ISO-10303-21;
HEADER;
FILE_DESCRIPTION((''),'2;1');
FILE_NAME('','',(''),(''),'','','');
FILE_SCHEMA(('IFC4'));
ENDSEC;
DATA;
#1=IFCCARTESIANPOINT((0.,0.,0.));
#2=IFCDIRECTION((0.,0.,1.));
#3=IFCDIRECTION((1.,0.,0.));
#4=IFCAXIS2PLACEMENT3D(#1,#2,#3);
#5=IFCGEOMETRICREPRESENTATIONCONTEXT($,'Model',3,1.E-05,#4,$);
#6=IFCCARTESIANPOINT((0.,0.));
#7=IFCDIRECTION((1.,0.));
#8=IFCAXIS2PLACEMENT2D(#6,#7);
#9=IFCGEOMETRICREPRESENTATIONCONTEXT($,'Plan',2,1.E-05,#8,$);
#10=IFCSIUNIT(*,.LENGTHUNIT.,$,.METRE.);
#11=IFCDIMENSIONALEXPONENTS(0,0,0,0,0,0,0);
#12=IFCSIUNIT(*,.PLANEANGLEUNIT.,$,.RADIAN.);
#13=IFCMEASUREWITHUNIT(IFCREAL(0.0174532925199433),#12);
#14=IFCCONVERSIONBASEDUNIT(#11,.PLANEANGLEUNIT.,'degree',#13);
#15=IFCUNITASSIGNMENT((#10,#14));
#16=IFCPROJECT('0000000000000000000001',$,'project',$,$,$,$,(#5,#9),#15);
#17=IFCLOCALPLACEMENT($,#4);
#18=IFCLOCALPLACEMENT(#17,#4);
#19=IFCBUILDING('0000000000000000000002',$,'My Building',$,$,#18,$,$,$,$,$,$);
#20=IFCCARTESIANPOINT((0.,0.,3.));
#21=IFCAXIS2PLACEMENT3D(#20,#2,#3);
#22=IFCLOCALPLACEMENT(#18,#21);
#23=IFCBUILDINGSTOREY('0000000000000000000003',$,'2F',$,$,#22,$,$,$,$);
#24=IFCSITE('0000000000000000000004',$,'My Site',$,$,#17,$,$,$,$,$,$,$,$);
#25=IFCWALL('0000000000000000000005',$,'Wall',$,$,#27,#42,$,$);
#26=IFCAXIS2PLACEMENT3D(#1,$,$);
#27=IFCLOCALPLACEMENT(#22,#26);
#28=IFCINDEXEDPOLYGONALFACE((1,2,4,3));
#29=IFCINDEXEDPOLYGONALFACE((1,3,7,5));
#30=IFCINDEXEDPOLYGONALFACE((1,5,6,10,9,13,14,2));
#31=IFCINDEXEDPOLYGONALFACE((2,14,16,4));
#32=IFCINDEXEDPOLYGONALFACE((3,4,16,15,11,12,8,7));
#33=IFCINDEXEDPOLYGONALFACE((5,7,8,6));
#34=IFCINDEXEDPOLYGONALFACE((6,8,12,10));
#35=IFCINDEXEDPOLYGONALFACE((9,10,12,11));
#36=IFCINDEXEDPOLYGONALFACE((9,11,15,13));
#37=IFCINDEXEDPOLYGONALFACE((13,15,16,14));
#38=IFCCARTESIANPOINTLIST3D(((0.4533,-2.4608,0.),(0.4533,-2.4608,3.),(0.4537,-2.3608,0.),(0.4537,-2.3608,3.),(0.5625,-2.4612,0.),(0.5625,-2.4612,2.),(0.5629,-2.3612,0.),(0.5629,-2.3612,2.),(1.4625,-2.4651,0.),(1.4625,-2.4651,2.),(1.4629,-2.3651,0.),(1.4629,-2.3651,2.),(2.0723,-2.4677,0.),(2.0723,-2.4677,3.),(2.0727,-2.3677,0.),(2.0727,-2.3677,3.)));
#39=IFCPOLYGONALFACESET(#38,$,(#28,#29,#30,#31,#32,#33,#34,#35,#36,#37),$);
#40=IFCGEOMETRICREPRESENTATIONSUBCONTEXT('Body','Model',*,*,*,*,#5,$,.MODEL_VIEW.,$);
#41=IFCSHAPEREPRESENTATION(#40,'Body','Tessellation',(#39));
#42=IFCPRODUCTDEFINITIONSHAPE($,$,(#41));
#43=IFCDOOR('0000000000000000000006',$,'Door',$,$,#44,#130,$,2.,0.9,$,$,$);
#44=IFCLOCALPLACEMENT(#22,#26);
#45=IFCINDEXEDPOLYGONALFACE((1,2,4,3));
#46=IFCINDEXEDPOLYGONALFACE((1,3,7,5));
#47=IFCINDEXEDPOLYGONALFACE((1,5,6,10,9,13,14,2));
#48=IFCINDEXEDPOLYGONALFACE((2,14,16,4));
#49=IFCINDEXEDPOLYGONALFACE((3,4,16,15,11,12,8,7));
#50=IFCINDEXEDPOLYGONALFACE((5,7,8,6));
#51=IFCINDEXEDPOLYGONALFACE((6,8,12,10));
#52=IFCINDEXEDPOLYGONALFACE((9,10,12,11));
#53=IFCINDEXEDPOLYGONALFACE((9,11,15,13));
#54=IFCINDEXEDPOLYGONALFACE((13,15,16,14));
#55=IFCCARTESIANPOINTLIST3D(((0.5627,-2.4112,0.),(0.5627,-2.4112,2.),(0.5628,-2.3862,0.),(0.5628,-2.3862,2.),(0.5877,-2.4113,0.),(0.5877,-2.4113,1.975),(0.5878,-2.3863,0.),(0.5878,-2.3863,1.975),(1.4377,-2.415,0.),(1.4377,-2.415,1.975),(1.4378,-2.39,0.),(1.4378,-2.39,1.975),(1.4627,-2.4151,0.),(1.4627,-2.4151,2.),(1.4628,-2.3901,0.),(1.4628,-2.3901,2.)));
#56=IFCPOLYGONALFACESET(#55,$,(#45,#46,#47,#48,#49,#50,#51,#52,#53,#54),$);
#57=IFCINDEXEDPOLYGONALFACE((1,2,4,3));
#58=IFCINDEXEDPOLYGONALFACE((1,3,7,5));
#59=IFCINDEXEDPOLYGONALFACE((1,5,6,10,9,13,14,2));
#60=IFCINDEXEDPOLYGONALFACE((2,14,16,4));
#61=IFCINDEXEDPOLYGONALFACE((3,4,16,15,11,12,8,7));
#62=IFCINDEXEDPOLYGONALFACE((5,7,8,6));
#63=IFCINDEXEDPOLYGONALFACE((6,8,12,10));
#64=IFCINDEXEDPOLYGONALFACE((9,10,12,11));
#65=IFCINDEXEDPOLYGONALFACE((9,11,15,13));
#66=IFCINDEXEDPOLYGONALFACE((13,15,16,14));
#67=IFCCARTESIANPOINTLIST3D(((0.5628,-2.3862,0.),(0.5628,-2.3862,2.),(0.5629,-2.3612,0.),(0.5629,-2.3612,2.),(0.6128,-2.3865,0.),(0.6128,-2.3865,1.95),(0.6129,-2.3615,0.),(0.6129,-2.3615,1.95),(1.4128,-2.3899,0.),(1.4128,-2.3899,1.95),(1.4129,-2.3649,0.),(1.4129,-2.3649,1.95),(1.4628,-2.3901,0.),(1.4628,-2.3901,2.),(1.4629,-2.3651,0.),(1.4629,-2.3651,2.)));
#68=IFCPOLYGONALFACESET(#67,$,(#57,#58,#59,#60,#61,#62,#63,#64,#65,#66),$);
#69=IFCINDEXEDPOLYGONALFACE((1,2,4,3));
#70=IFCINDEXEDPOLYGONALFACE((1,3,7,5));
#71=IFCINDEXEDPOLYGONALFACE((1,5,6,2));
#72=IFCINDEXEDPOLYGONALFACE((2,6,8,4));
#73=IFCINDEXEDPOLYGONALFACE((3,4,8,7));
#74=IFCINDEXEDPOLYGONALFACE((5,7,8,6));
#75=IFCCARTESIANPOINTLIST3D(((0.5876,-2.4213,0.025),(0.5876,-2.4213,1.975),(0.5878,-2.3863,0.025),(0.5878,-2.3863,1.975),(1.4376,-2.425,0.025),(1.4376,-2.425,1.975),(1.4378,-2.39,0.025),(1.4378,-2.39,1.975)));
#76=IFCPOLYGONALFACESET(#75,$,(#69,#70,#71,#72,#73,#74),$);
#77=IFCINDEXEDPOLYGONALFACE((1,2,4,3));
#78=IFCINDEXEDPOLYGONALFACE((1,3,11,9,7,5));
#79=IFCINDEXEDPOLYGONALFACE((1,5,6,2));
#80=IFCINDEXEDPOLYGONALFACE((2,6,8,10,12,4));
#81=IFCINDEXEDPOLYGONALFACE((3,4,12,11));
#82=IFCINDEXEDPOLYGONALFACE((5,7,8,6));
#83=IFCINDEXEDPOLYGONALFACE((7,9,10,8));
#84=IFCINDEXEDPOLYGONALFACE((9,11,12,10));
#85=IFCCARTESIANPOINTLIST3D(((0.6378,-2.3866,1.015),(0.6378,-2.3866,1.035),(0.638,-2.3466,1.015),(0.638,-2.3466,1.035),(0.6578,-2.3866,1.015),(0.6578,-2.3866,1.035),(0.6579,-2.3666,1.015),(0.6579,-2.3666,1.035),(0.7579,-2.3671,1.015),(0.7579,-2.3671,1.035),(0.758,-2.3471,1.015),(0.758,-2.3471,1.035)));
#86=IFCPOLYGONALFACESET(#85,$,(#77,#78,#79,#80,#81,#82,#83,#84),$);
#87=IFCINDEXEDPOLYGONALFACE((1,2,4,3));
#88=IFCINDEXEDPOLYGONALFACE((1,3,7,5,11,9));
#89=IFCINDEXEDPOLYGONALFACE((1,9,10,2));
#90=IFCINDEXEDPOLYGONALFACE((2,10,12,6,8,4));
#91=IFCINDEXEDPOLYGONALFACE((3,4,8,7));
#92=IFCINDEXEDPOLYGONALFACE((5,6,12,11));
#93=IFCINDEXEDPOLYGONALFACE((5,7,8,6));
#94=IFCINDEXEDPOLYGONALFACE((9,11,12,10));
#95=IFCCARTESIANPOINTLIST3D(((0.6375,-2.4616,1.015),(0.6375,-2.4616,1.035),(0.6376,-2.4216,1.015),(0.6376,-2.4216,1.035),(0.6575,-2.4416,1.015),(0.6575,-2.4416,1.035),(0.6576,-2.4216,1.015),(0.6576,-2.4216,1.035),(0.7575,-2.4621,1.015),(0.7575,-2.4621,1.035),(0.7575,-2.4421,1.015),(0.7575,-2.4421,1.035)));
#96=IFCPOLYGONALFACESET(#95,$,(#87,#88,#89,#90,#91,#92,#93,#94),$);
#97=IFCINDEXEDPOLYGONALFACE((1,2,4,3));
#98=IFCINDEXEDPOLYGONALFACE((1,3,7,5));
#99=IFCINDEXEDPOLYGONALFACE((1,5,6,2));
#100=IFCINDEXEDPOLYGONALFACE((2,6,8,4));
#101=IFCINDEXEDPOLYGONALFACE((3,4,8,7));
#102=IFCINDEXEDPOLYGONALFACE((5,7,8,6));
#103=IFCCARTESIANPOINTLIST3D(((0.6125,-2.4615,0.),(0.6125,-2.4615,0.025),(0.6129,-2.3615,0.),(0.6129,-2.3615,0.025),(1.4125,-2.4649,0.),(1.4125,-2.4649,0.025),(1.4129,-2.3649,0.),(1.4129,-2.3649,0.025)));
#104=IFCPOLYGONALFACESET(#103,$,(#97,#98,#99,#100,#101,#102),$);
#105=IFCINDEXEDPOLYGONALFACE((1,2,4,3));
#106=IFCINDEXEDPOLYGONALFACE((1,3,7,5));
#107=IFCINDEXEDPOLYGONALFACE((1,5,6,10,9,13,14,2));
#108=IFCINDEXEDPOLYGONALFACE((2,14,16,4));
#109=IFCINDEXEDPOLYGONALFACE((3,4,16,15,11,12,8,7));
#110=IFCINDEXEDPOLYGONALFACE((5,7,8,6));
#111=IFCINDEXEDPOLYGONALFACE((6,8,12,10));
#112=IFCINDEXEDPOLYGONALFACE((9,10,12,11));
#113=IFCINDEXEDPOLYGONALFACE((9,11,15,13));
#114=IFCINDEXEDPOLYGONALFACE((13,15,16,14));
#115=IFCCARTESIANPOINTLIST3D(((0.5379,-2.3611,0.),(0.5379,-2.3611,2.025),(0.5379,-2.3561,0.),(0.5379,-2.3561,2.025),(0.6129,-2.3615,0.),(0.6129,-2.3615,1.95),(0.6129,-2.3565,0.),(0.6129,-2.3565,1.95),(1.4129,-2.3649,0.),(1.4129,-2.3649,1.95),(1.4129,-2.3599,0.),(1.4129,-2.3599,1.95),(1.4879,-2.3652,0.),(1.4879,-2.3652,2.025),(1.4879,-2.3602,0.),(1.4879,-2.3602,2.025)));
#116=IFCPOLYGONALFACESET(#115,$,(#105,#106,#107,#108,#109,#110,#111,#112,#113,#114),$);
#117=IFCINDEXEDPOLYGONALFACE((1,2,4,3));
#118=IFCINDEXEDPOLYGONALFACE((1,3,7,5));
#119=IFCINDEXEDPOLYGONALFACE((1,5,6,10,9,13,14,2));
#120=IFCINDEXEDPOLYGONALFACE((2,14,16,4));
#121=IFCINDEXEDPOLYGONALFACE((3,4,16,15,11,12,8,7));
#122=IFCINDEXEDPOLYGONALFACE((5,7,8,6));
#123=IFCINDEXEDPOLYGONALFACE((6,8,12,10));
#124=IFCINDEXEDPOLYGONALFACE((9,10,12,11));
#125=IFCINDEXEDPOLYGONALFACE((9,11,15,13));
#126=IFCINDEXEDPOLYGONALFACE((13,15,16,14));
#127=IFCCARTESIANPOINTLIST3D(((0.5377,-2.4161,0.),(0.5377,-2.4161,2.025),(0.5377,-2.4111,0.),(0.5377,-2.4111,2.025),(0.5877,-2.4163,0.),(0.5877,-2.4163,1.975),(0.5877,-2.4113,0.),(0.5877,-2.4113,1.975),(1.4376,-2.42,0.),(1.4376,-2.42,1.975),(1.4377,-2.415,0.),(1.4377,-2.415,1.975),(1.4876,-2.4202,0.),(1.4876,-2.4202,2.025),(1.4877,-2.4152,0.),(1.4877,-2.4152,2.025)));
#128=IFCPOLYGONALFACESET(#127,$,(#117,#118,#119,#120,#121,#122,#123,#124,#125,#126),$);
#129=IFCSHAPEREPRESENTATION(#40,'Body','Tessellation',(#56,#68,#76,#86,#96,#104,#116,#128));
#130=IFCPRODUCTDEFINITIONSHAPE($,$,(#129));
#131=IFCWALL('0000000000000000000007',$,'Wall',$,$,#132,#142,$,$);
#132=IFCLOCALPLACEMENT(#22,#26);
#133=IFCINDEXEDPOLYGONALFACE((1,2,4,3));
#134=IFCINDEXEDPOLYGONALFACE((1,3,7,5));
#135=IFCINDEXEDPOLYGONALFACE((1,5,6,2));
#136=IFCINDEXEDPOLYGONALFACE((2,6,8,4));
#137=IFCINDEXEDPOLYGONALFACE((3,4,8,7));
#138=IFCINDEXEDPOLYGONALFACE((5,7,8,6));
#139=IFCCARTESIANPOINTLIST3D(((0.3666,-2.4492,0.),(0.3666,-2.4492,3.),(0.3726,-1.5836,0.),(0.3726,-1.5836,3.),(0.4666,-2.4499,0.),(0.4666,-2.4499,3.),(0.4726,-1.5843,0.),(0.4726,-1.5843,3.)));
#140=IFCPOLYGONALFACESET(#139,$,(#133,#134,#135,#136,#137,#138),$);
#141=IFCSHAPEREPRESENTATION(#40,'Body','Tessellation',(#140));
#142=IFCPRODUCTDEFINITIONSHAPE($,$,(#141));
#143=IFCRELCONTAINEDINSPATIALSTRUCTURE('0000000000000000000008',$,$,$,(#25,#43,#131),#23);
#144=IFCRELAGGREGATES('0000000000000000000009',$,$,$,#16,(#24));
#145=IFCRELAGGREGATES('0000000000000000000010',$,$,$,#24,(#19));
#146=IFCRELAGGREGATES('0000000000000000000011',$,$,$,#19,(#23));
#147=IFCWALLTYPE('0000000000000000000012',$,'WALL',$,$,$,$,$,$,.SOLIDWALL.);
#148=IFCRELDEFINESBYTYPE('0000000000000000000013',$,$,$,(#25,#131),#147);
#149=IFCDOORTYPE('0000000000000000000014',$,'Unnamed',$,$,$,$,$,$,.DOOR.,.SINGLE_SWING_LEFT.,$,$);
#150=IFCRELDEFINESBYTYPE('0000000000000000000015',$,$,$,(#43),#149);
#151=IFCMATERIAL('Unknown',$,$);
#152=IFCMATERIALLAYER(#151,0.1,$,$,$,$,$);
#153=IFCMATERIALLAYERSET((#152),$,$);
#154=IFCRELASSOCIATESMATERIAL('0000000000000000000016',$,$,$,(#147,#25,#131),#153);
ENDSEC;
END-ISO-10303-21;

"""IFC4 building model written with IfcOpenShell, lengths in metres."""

from ifc_helpers import new_model, entity, si_unit, converted_unit, frame, origin_with_axes, origin_2d_with_axis, place, context, subcontext, project, spatial, line, indexed_curve, outline, extrude, shape, source, transform, mapped, material, layer, layer_set, layer_usage, type_object, type_shapes, element, fill, save


model = new_model("IFC4")

# Units and contexts
model_context = context("Model", 3, precision=1e-05, world=origin_with_axes())
plan_context = context("Plan", 2, precision=1e-05, world=origin_2d_with_axis())
body_context_1 = subcontext(model_context, "Body", "Model", "MODEL_VIEW")
body_context_2 = subcontext(plan_context, "Body", "Plan", "PLAN_VIEW")
ifc_project = project(units=[si_unit("LENGTHUNIT", "METRE"), converted_unit("PLANEANGLEUNIT", "degree", entity("IfcReal", 0.0174532925199433), si_unit("PLANEANGLEUNIT", "RADIAN"), dimensions=[0, 0, 0, 0, 0, 0, 0])], contexts=[model_context, plan_context])

# Site, building, storey
site_placement = place(None, origin_with_axes())
site = spatial("IfcSite", under=ifc_project, at=site_placement, Name="My Site")
building_placement = place(site_placement, origin_with_axes())
building = spatial("IfcBuilding", under=site, at=building_placement, Name="My Building")
storey_placement = place(building_placement, frame((0.0, 0.0, 3.0), z_axis=(0.0, 0.0, 1.0), x_axis=(1.0, 0.0, 0.0)))
storey = spatial("IfcBuildingStorey", under=building, at=storey_placement, Name="2F")

# Shared definitions
ifc_material = material(Name="Unknown")

# Shared definitions
ifc_layer_1 = layer(ifc_material, 0.1)
ifc_layer_set_1 = layer_set([ifc_layer_1])
wall_type = type_object("IfcWallType", Name="WALL", PredefinedType="SOLIDWALL", material=ifc_layer_set_1)

# Shared definitions
shared_shape_1 = source(origin_with_axes(), body_context_1, "Body", "SweptSolid", [
    extrude(outline(indexed_curve([(0.0, 0.0), (0.9, 0.0), (0.9, 2.0), (0.0, 2.0)], segments=[line(1, 2, 3, 4, 1)])), frame((0.0, -0.6, 0.0), z_axis=(0.0, -1.0, 0.0), x_axis=(1.0, 0.0, 0.0)), (0.0, 0.0, -1.0), 1.2),
])
door_type = type_object("IfcDoorType", Name="Unnamed", OperationType="SINGLE_SWING_LEFT", PredefinedType="DOOR")
shared_shape_2 = source(origin_with_axes(), body_context_1, "Body", "SweptSolid", [
    extrude(outline(indexed_curve([(0.0, 0.0), (0.0, 2.0), (0.9, 2.0), (0.9, 0.0), (0.875, 0.0), (0.875, 1.975), (0.025, 1.975), (0.025, 0.0)], segments=[line(1, 2, 3, 4, 5, 6, 7, 8, 1)])), frame((0.0, 0.025, 0.0), z_axis=(0.0, -1.0, 0.0), x_axis=(1.0, 0.0, 0.0)), (0.0, 0.0, -1.0), 0.025),
    extrude(outline(indexed_curve([(0.0, 0.0), (0.0, 2.0), (0.9, 2.0), (0.9, 0.0), (0.85, 0.0), (0.85, 1.95), (0.05, 1.95), (0.05, 0.0)], segments=[line(1, 2, 3, 4, 5, 6, 7, 8, 1)])), frame((0.0, 0.0, 0.0), z_axis=(0.0, -1.0, 0.0), x_axis=(1.0, 0.0, 0.0)), (0.0, 0.0, -1.0), 0.025),
    extrude(outline(indexed_curve([(0.0, 0.0), (0.85, 0.0), (0.85, 0.035), (0.0, 0.035)], segments=[line(1, 2, 3, 4, 1)])), frame((0.025, 0.025, 0.025), z_axis=(0.0, 0.0, 1.0), x_axis=(1.0, 0.0, 0.0)), (0.0, 0.0, 1.0), 1.95),
    extrude(outline(indexed_curve([(0.0, 0.0), (0.0, -0.04), (-0.12, -0.04), (-0.12, -0.02), (-0.02, -0.02), (-0.02, 0.0)], segments=[line(1, 2, 3, 4, 5, 6, 1)])), frame((0.825, 0.025, 1.015), z_axis=(0.0, 0.0, 1.0), x_axis=(1.0, 0.0, 0.0)), (0.0, 0.0, 1.0), 0.02),
    extrude(outline(indexed_curve([(0.0, 0.0), (0.0, 0.04), (-0.12, 0.04), (-0.12, 0.02), (-0.02, 0.02), (-0.02, 0.0)], segments=[line(1, 2, 3, 4, 5, 6, 1)])), frame((0.825, 0.06, 1.015), z_axis=(0.0, 0.0, 1.0), x_axis=(1.0, 0.0, 0.0)), (0.0, 0.0, 1.0), 0.02),
    extrude(outline(indexed_curve([(0.0, 0.0), (0.8, 0.0), (0.8, 0.1), (0.0, 0.1)], segments=[line(1, 2, 3, 4, 1)])), frame((0.05, 0.0, 0.0), z_axis=(0.0, 0.0, 1.0), x_axis=(1.0, 0.0, 0.0)), (0.0, 0.0, 1.0), 0.025),
    extrude(outline(indexed_curve([(0.0, 0.0), (0.0, 2.025), (0.95, 2.025), (0.95, 0.0), (0.875, 0.0), (0.875, 1.95), (0.075, 1.95), (0.075, 0.0)], segments=[line(1, 2, 3, 4, 5, 6, 7, 8, 1)])), frame((-0.025, -0.005, 0.0), z_axis=(0.0, -1.0, 0.0), x_axis=(1.0, 0.0, 0.0)), (0.0, 0.0, -1.0), 0.005),
    extrude(outline(indexed_curve([(0.0, 0.0), (0.0, 2.025), (0.95, 2.025), (0.95, 0.0), (0.9, 0.0), (0.9, 1.975), (0.05, 1.975), (0.05, 0.0)], segments=[line(1, 2, 3, 4, 5, 6, 7, 8, 1)])), frame((-0.025, 0.05, 0.0), z_axis=(0.0, -1.0, 0.0), x_axis=(1.0, 0.0, 0.0)), (0.0, 0.0, -1.0), 0.005),
])
shared_shape_3 = source(origin_with_axes(), body_context_2, "Body", "Curve2D", [
    entity("IfcIndexedPolyCurve", entity("IfcCartesianPointList2D", [[0.0, 0.0], [0.0, 0.05], [0.025, 0.05], [0.025, 0.025], [0.05, 0.025], [0.05, 0.0]]), [entity("IfcLineIndex", [1, 2, 3, 4, 5, 6, 1])]),
    entity("IfcIndexedPolyCurve", entity("IfcCartesianPointList2D", [[0.9, 0.0], [0.9, 0.05], [0.875, 0.05], [0.875, 0.025], [0.85, 0.025], [0.85, 0.0]]), [entity("IfcLineIndex", [1, 2, 3, 4, 5, 6, 1])]),
    entity("IfcTrimmedCurve", entity("IfcEllipse", entity("IfcAxis2Placement2D", entity("IfcCartesianPoint", [0.06, 0.05]), entity("IfcDirection", [1.0, 0.0])), 0.815, 0.85), [entity("IfcCartesianPoint", [0.875, 0.05])], [entity("IfcCartesianPoint", [0.06, 0.9])], True, "CARTESIAN"),
    entity("IfcIndexedPolyCurve", entity("IfcCartesianPointList2D", [[0.025, 0.05], [0.06, 0.05], [0.06, 0.9], [0.025, 0.9]]), [entity("IfcLineIndex", [1, 2, 3, 4, 1])]),
])
type_shapes(door_type, [shared_shape_2, shared_shape_3])

# Wall, opening, door
ifc_layer_usage_1 = layer_usage(ifc_layer_set_1, "AXIS2", "POSITIVE", 0.0)
wall_1_placement = place(storey_placement, frame((2.0727, -2.3677, 0.0), z_axis=(0.0, 0.0, 1.0), x_axis=(-0.999991, 0.00431, 0.0)))
wall_1 = element("IfcWall", 1, at=wall_1_placement, inside=storey, type_object=wall_type, material=ifc_layer_usage_1, Name="Wall", context=body_context_1, shape_type="SweptSolid", body=[
    extrude(outline(indexed_curve([(0.0, 0.0), (0.0, 0.1), (1.619, 0.1), (1.619, 0.0)], segments=[line(1, 2, 3, 4, 1)])), origin_with_axes(), (0.0, 0.0, 1.0), 3.0),
])
opening_1_placement = place(wall_1_placement, frame((0.6098, 0.0, 0.0), z_axis=(0.0, 0.0, 1.0), x_axis=(1.0, 0.0, 0.0)))
opening_1 = element("IfcOpeningElement", 2, at=opening_1_placement, cuts=wall_1, PredefinedType="OPENING", context=body_context_1, shape_type="MappedRepresentation", body=[
    mapped(shared_shape_1, transform((0.0, 0.0, 0.0), x_axis=(1.0, 0.0, 0.0), y_axis=(0.0, 1.0, 0.0), z_axis=(0.0, 0.0, 1.0), scale=1.0)),
])
door_1_placement = place(opening_1_placement, frame((0.0, 0.0, 0.0), z_axis=(0.0, 0.0, 1.0), x_axis=(1.0, 0.0, 0.0)))
door_1 = element("IfcDoor", 3, at=door_1_placement, inside=storey, type_object=door_type, Name="Door", OverallHeight=2.0, OverallWidth=0.9, shapes=[
    shape(body_context_1, "Body", "MappedRepresentation", [mapped(shared_shape_2, transform((0.0, 0.0, 0.0), x_axis=(1.0, 0.0, 0.0), y_axis=(0.0, 1.0, 0.0), z_axis=(0.0, 0.0, 1.0), scale=1.0))]),
    shape(body_context_2, "Body", "MappedRepresentation", [mapped(shared_shape_3, transform((0.0, 0.0, 0.0), x_axis=(1.0, 0.0, 0.0), y_axis=(0.0, 1.0, 0.0), z_axis=(0.0, 0.0, 1.0), scale=1.0))]),
])
fill(opening_1, door_1)

# Wall
ifc_layer_usage_2 = layer_usage(ifc_layer_set_1, "AXIS2", "POSITIVE", 0.0)
wall_2_placement = place(storey_placement, frame((0.3726, -1.5836, 0.0), z_axis=(0.0, 0.0, 1.0), x_axis=(-0.006993, -0.999976, 0.0)))
element("IfcWall", 4, at=wall_2_placement, inside=storey, type_object=wall_type, material=ifc_layer_usage_2, Name="Wall", context=body_context_1, shape_type="SweptSolid", body=[
    extrude(outline(indexed_curve([(0.0, 0.0), (0.0, 0.1), (0.8656, 0.1), (0.8656, 0.0)], segments=[line(1, 2, 3, 4, 1)])), origin_with_axes(), (0.0, 0.0, 1.0), 3.0),
])

save(model, "model.ifc")
